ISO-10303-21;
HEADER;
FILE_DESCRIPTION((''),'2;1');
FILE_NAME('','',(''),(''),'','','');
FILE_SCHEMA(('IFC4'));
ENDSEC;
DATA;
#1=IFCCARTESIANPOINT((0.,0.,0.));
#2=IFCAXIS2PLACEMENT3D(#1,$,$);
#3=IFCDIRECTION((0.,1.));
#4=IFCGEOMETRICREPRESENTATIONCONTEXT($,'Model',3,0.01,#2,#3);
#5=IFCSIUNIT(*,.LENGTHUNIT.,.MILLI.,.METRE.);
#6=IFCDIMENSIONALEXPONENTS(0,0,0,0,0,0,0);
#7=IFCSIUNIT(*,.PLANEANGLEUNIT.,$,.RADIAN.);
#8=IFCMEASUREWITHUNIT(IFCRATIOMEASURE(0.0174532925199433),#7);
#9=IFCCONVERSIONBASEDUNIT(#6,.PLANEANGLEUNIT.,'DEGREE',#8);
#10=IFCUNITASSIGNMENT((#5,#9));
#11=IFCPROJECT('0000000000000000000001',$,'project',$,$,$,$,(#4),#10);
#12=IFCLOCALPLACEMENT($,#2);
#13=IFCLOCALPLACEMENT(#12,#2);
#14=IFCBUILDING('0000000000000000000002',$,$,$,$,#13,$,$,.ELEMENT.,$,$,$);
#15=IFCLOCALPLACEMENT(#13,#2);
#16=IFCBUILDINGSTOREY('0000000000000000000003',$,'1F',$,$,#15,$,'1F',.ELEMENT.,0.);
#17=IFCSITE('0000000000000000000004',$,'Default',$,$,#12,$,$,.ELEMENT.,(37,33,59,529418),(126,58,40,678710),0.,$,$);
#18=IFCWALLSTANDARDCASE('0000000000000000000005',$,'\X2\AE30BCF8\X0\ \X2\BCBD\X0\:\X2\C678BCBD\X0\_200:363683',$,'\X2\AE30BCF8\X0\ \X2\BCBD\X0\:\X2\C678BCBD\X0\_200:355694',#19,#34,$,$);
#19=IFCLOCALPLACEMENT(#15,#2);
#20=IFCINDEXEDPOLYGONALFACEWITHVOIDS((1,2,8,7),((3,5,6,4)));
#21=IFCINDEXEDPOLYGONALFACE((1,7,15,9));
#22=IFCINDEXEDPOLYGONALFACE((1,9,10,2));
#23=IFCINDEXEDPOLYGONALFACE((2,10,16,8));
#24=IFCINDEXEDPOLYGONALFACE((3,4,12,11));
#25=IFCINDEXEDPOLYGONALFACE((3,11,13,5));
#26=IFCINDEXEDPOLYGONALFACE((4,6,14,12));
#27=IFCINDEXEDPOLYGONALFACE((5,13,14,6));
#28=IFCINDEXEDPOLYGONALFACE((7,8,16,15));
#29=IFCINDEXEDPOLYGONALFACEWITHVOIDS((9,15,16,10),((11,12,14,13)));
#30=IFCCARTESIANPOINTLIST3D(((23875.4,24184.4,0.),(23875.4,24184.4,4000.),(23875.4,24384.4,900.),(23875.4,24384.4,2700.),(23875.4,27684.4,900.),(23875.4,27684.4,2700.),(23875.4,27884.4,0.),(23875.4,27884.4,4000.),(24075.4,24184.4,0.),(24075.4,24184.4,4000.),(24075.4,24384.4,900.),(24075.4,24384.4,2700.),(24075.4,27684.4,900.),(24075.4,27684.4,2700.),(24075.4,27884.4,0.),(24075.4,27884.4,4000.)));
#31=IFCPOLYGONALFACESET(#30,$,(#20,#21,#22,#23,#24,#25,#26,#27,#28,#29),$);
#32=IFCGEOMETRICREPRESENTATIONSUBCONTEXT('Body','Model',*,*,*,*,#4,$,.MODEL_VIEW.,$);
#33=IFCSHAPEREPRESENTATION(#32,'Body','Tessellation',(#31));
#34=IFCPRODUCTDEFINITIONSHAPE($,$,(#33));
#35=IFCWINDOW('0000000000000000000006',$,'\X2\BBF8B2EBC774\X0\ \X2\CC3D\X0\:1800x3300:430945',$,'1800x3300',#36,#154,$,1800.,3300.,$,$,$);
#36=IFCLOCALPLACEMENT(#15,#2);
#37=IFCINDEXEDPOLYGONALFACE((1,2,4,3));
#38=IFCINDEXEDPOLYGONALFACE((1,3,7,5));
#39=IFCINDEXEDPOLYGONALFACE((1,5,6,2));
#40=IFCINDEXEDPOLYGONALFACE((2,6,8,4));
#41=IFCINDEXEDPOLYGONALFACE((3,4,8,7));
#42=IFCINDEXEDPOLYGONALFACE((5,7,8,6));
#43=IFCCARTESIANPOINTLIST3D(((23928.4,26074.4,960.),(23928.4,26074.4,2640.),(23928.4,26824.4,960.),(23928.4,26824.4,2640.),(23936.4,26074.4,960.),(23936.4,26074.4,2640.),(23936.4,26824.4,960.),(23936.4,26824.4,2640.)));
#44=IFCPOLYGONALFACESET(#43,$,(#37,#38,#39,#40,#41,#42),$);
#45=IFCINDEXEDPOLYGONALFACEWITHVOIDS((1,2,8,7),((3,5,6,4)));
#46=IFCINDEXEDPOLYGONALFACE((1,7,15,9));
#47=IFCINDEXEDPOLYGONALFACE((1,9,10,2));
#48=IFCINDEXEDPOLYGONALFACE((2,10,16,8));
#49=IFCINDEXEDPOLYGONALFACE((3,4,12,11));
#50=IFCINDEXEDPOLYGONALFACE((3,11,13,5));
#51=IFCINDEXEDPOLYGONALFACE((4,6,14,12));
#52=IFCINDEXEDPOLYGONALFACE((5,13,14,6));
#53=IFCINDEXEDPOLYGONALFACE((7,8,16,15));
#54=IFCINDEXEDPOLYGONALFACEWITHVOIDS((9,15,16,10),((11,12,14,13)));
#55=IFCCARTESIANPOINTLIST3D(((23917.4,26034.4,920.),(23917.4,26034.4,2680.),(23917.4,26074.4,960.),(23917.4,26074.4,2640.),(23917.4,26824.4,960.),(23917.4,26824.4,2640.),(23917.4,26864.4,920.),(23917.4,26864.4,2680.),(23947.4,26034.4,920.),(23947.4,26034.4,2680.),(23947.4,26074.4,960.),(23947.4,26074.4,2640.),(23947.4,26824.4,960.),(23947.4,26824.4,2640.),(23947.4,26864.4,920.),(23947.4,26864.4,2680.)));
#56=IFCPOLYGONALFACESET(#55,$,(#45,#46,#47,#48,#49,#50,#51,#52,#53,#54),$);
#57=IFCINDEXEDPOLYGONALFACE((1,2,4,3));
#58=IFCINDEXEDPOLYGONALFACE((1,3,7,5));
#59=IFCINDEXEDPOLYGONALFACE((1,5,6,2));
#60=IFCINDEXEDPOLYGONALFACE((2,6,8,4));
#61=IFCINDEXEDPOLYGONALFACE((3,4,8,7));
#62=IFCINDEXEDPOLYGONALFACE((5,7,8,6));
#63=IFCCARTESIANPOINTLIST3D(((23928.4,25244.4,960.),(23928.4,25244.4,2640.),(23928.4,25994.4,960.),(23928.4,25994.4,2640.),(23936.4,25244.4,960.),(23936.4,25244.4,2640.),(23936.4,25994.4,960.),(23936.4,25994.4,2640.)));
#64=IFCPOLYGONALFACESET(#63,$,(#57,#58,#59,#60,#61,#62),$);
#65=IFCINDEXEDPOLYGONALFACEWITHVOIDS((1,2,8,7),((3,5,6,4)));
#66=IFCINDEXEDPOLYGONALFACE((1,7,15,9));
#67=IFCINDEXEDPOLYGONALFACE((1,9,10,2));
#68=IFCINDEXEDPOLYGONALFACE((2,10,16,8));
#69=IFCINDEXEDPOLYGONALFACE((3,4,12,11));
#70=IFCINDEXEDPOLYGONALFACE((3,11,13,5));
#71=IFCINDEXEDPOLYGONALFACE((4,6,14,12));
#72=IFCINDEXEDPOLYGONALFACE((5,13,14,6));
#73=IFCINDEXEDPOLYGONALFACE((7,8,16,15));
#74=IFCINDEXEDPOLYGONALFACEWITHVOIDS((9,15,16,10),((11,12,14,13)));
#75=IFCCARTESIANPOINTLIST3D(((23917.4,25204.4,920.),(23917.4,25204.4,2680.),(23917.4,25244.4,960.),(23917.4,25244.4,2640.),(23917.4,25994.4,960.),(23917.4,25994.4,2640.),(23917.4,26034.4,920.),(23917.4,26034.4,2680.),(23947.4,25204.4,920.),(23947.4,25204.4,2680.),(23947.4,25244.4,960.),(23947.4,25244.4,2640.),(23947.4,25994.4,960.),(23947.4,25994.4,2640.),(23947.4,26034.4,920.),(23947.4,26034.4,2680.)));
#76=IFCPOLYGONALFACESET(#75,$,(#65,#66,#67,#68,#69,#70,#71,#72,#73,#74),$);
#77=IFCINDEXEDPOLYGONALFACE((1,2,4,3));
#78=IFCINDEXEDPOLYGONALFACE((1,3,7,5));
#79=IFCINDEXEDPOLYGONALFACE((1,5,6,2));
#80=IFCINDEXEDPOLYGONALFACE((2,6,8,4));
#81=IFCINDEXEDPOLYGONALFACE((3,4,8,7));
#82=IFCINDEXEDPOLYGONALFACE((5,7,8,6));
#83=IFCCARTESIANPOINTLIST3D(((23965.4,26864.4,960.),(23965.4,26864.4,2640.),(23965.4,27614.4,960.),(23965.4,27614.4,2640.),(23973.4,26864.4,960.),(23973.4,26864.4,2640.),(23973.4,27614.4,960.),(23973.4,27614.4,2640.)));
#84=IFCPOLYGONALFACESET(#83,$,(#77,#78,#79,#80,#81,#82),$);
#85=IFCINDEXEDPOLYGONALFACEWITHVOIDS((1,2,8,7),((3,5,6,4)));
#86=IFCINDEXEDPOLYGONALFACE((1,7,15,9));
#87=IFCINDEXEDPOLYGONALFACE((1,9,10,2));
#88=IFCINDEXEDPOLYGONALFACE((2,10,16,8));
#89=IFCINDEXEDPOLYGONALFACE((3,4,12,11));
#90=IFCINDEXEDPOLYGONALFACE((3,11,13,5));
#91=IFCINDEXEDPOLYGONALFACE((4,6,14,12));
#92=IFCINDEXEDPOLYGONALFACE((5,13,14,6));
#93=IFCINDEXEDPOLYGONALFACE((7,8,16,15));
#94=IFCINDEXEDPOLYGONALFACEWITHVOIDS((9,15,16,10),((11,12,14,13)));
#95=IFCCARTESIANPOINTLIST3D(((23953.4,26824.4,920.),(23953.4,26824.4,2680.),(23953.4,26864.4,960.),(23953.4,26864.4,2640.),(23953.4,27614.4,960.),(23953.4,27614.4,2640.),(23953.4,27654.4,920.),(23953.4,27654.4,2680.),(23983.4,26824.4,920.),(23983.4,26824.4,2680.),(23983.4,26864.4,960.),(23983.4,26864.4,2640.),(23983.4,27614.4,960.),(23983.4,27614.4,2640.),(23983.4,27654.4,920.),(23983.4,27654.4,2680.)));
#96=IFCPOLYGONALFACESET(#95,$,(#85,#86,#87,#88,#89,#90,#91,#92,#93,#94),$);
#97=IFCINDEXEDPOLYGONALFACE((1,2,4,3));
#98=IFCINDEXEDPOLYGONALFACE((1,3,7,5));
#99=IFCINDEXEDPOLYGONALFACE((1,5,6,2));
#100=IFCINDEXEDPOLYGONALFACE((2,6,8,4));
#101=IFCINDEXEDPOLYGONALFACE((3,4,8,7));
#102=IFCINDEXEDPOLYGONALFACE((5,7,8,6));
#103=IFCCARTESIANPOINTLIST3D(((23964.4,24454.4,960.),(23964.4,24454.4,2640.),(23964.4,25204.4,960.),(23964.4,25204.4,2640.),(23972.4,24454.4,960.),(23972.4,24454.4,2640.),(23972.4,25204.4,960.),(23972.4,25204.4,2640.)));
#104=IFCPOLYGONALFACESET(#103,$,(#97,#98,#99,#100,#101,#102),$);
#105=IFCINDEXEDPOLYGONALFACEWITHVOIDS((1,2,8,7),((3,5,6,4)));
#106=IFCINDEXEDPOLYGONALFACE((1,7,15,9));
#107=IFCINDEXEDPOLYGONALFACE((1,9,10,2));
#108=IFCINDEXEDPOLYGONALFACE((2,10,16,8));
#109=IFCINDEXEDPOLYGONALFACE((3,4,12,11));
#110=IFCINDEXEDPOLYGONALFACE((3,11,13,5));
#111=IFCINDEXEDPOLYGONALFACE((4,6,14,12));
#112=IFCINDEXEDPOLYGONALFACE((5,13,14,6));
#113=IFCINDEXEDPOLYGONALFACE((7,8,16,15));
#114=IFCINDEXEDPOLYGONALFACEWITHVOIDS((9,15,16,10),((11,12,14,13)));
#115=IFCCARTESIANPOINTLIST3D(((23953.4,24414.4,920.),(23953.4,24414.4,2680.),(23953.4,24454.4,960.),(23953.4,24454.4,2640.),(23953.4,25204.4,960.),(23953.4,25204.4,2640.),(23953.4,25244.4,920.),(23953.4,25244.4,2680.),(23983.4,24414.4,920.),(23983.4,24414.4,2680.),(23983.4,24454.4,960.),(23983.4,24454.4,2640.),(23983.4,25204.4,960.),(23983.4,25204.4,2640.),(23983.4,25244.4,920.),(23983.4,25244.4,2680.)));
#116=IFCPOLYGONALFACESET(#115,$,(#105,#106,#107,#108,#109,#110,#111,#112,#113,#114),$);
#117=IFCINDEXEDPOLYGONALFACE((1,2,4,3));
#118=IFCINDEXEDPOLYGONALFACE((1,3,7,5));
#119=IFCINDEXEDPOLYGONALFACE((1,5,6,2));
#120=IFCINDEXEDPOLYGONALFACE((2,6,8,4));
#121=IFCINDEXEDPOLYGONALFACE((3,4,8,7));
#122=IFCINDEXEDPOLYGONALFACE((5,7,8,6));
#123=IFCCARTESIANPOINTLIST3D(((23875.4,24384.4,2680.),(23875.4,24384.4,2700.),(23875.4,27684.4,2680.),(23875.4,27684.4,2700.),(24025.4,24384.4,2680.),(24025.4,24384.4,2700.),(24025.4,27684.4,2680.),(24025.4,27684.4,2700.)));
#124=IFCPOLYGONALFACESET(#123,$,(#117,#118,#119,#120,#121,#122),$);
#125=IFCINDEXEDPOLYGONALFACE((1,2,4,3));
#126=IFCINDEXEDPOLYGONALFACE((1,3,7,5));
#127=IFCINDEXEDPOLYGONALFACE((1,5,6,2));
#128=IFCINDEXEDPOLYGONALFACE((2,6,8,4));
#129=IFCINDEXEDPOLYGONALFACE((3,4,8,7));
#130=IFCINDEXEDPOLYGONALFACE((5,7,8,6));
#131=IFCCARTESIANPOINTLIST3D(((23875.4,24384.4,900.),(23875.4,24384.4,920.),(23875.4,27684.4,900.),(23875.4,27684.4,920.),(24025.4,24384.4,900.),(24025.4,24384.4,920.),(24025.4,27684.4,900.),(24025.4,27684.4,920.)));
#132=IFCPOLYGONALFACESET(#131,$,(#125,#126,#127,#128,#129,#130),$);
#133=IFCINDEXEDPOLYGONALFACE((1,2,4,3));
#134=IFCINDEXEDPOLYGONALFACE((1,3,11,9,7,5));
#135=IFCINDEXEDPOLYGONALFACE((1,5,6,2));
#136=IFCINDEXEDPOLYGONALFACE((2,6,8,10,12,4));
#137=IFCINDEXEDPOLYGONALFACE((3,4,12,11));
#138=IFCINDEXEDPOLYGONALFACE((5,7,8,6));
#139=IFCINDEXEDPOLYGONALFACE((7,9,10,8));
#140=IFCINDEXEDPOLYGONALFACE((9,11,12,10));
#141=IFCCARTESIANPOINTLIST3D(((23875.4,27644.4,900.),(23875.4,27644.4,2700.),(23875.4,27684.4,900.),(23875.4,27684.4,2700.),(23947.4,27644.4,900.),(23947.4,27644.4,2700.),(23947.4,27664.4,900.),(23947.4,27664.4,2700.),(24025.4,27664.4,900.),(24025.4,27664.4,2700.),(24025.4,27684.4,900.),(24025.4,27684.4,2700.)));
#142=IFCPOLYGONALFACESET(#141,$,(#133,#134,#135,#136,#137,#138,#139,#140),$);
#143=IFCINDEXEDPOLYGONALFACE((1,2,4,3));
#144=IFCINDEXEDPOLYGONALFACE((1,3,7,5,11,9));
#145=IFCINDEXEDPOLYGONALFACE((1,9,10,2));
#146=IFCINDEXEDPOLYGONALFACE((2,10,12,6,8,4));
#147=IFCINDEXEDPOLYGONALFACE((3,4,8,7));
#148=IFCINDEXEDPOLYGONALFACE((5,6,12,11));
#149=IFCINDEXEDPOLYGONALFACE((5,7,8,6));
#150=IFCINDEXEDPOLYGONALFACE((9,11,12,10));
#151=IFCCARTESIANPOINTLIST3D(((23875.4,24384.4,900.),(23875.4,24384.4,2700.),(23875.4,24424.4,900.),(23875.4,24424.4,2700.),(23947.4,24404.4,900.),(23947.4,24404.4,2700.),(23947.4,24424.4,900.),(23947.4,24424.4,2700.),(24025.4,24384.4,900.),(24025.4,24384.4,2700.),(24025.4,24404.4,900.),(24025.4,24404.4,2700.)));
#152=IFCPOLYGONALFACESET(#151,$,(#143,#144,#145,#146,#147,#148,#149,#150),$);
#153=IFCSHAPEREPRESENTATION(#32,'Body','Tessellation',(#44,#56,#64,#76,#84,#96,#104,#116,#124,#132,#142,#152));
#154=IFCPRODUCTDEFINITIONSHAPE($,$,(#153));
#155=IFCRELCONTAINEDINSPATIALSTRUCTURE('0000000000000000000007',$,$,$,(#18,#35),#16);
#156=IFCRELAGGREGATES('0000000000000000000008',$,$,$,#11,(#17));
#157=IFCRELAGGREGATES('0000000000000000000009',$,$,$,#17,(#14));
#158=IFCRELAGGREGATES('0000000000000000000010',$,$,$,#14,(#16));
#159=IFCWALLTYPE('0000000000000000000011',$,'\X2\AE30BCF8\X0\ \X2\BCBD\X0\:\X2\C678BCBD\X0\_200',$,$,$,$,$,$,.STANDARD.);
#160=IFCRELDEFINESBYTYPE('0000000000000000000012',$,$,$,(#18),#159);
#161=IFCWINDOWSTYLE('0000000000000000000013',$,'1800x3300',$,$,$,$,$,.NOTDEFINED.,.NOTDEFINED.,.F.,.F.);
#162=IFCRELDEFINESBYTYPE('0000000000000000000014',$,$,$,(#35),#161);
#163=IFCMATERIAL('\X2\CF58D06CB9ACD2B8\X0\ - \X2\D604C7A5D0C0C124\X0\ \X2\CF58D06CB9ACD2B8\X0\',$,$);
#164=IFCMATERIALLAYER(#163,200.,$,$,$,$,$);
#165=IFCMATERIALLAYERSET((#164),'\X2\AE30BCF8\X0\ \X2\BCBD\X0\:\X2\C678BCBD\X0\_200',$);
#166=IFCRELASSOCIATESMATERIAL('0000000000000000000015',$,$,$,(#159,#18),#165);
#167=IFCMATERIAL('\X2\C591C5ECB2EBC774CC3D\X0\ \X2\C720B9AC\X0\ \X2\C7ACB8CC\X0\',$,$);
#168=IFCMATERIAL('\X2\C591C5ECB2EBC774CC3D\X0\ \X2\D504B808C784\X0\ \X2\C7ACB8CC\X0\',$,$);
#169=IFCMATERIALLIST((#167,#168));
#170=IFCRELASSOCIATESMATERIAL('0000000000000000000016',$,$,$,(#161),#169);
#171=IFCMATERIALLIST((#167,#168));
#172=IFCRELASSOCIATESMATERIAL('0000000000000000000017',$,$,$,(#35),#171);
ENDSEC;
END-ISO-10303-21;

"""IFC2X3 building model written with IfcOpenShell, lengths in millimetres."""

from ifc_helpers import new_model, entity, si_unit, converted_unit, direction, frame, frame_2d, origin, origin_2d_with_axis, place, context, subcontext, project, spatial, polyline, rectangle, outline, extrude, source, transform, mapped, material, material_list, layer, layer_set, layer_usage, type_object, type_shapes, element, fill, save


model = new_model("IFC2X3")

# Units and contexts
model_context = context("Model", 3, precision=0.01, world=origin(), true_north=direction((0.0, 1.0)))
body_context = subcontext(model_context, "Body", "Model", "MODEL_VIEW")
ifc_project = project(units=[si_unit("LENGTHUNIT", "METRE", prefix="MILLI"), converted_unit("PLANEANGLEUNIT", "DEGREE", entity("IfcRatioMeasure", 0.0174532925199433), si_unit("PLANEANGLEUNIT", "RADIAN"), dimensions=[0, 0, 0, 0, 0, 0, 0])], contexts=[model_context])

# Site, building, storey
site_placement = place(None, origin())
site = spatial("IfcSite", under=ifc_project, at=site_placement, Name="Default", CompositionType="ELEMENT", RefLatitude=(37, 33, 59, 529418), RefLongitude=(126, 58, 40, 678710), RefElevation=0.0)
building_placement = place(site_placement, origin())
building = spatial("IfcBuilding", under=site, at=building_placement, CompositionType="ELEMENT")
storey_placement = place(building_placement, origin())
storey = spatial("IfcBuildingStorey", under=building, at=storey_placement, Name="1F", LongName="1F", CompositionType="ELEMENT", Elevation=0.0)

# Shared definitions
ifc_material_1 = material(Name="콘크리트 - 현장타설 콘크리트")

# Wall, opening, window
ifc_layer_1 = layer(ifc_material_1, 200.0)
ifc_layer_set_1 = layer_set([ifc_layer_1], Name="기본 벽:외벽_200")
ifc_layer_usage_1 = layer_usage(ifc_layer_set_1, "AXIS2", "NEGATIVE", 100.0)
wall_type_1 = type_object("IfcWallType", Name="기본 벽:외벽_200", PredefinedType="STANDARD", material=ifc_layer_set_1)
wall_1_placement = place(storey_placement, frame((23975.4, 24184.4, 0.0), z_axis=(0.0, 0.0, 1.0), x_axis=(0.0, 1.0, 0.0)))
wall_1 = element("IfcWallStandardCase", 1, at=wall_1_placement, inside=storey, type_object=wall_type_1, material=ifc_layer_usage_1, Name="기본 벽:외벽_200:363683", ObjectType="기본 벽:외벽_200:355694", context=body_context, shape_type="SweptSolid", body=[
    extrude(rectangle(XDim=3700.0, YDim=200.0, at=frame_2d((1850.0, 0.0), x_axis=(-1.0, 0.0))), origin(), (0.0, 0.0, 1.0), 4000.0),
])
opening_1_placement = place(wall_1_placement, frame((200.0, -100.0, 900.0)))
opening_1 = element("IfcOpeningElement", 2, at=opening_1_placement, cuts=wall_1, ObjectType="Opening", context=body_context, shape_type="SweptSolid", body=[
    extrude(rectangle(XDim=1800.0, YDim=3300.0, at=frame_2d((900.0, 1650.0), x_axis=(1.0, 0.0))), frame((0.0, 0.0, 0.0), z_axis=(0.0, 1.0, 0.0), x_axis=(0.0, 0.0, 1.0)), (0.0, 0.0, 1.0), 200.0),
])
ifc_material_2 = material(Name="양여닫이창 유리 재료")
ifc_material_3 = material(Name="양여닫이창 프레임 재료")
ifc_material_list_1 = material_list([ifc_material_2, ifc_material_3])
ifc_material_list_2 = material_list([ifc_material_2, ifc_material_3])
window_style_1 = type_object("IfcWindowStyle", Name="1800x3300", ConstructionType="NOTDEFINED", OperationType="NOTDEFINED", ParameterTakesPrecedence=False, Sizeable=False, material=ifc_material_list_2)
shared_shape_1 = source(origin(), body_context, "Body", "SweptSolid", [
    extrude(rectangle(XDim=8.0, YDim=750.0, at=frame_2d((0.0, 0.0), x_axis=(1.0, 0.0))), frame((2065.0, 143.0, 60.0), z_axis=(0.0, 0.0, 1.0), x_axis=(0.0, 1.0, 0.0)), (0.0, 0.0, 1.0), 1680.0),
    extrude(outline(polyline([(-880.0, -415.0), (880.0, -415.0), (880.0, 415.0), (-880.0, 415.0), (-880.0, -415.0)]), holes=[polyline([(840.0, -375.0), (-840.0, -375.0), (-840.0, 375.0), (840.0, 375.0), (840.0, -375.0)])]), frame((2065.0, 128.0, 900.0), z_axis=(0.0, 1.0, 0.0), x_axis=(0.0, 0.0, -1.0)), (0.0, 0.0, 1.0), 30.0),
    extrude(rectangle(XDim=8.0, YDim=750.0, at=frame_2d((0.0, 0.0), x_axis=(1.0, 0.0))), frame((1235.0, 143.0, 60.0), z_axis=(0.0, 0.0, 1.0), x_axis=(0.0, 1.0, 0.0)), (0.0, 0.0, 1.0), 1680.0),
    extrude(outline(polyline([(-880.0, -415.0), (880.0, -415.0), (880.0, 415.0), (-880.0, 415.0), (-880.0, -415.0)]), holes=[polyline([(840.0, -375.0), (-840.0, -375.0), (-840.0, 375.0), (840.0, 375.0), (840.0, -375.0)])]), frame((1235.0, 128.0, 900.0), z_axis=(0.0, 1.0, 0.0), x_axis=(0.0, 0.0, -1.0)), (0.0, 0.0, 1.0), 30.0),
    extrude(rectangle(XDim=8.0, YDim=750.0, at=frame_2d((0.0, 0.0), x_axis=(1.0, 0.0))), frame((2855.0, 106.0, 60.0), z_axis=(0.0, 0.0, 1.0), x_axis=(0.0, 1.0, 0.0)), (0.0, 0.0, 1.0), 1680.0),
    extrude(outline(polyline([(-880.0, -415.0), (880.0, -415.0), (880.0, 415.0), (-880.0, 415.0), (-880.0, -415.0)]), holes=[polyline([(840.0, -375.0), (-840.0, -375.0), (-840.0, 375.0), (840.0, 375.0), (840.0, -375.0)])]), frame((2855.0, 92.0, 900.0), z_axis=(0.0, 1.0, 0.0), x_axis=(0.0, 0.0, -1.0)), (0.0, 0.0, 1.0), 30.0),
    extrude(rectangle(XDim=8.0, YDim=750.0, at=origin_2d_with_axis()), frame((445.0, 107.0, 60.0), z_axis=(0.0, 0.0, 1.0), x_axis=(0.0, 1.0, 0.0)), (0.0, 0.0, 1.0), 1680.0),
    extrude(outline(polyline([(-880.0, -415.0), (880.0, -415.0), (880.0, 415.0), (-880.0, 415.0), (-880.0, -415.0)]), holes=[polyline([(840.0, -375.0), (-840.0, -375.0), (-840.0, 375.0), (840.0, 375.0), (840.0, -375.0)])]), frame((445.0, 92.0, 900.0), z_axis=(0.0, 1.0, 0.0), x_axis=(0.0, 0.0, -1.0)), (0.0, 0.0, 1.0), 30.0),
    extrude(rectangle(XDim=3300.0, YDim=150.0, at=origin_2d_with_axis()), frame((1650.0, 125.0, 1780.0), z_axis=(0.0, 0.0, 1.0), x_axis=(-1.0, 0.0, 0.0)), (0.0, 0.0, 1.0), 20.0),
    extrude(rectangle(XDim=3300.0, YDim=150.0, at=origin_2d_with_axis()), frame((1650.0, 125.0, 0.0), z_axis=(0.0, 0.0, 1.0), x_axis=(-1.0, 0.0, 0.0)), (0.0, 0.0, 1.0), 20.0),
    extrude(outline(polyline([(-74.0, -20.0), (-2.0, -20.0), (-2.0, 0.0), (76.0, 0.0), (76.0, 20.0), (-74.0, 20.0), (-74.0, -20.0)])), frame((3280.0, 126.0, 0.0), z_axis=(0.0, 0.0, 1.0), x_axis=(0.0, -1.0, 0.0)), (0.0, 0.0, 1.0), 1800.0),
    extrude(outline(polyline([(-20.0, -74.0), (20.0, -74.0), (20.0, 76.0), (0.0, 76.0), (0.0, -2.0), (-20.0, -2.0), (-20.0, -74.0)])), frame((20.0, 126.0, 0.0), z_axis=(0.0, 0.0, 1.0), x_axis=(-1.0, 0.0, 0.0)), (0.0, 0.0, 1.0), 1800.0),
])
type_shapes(window_style_1, [shared_shape_1])
window_1_placement = place(opening_1_placement, origin())
window_1 = element("IfcWindow", 3, at=window_1_placement, inside=storey, type_object=window_style_1, material=ifc_material_list_1, Name="미닫이 창:1800x3300:430945", ObjectType="1800x3300", OverallHeight=1800.0, OverallWidth=3300.0, context=body_context, shape_type="MappedRepresentation", body=[
    mapped(shared_shape_1, transform((0.0, 0.0, 0.0), scale=1.0)),
])
fill(opening_1, window_1)

save(model, "model.ifc")
